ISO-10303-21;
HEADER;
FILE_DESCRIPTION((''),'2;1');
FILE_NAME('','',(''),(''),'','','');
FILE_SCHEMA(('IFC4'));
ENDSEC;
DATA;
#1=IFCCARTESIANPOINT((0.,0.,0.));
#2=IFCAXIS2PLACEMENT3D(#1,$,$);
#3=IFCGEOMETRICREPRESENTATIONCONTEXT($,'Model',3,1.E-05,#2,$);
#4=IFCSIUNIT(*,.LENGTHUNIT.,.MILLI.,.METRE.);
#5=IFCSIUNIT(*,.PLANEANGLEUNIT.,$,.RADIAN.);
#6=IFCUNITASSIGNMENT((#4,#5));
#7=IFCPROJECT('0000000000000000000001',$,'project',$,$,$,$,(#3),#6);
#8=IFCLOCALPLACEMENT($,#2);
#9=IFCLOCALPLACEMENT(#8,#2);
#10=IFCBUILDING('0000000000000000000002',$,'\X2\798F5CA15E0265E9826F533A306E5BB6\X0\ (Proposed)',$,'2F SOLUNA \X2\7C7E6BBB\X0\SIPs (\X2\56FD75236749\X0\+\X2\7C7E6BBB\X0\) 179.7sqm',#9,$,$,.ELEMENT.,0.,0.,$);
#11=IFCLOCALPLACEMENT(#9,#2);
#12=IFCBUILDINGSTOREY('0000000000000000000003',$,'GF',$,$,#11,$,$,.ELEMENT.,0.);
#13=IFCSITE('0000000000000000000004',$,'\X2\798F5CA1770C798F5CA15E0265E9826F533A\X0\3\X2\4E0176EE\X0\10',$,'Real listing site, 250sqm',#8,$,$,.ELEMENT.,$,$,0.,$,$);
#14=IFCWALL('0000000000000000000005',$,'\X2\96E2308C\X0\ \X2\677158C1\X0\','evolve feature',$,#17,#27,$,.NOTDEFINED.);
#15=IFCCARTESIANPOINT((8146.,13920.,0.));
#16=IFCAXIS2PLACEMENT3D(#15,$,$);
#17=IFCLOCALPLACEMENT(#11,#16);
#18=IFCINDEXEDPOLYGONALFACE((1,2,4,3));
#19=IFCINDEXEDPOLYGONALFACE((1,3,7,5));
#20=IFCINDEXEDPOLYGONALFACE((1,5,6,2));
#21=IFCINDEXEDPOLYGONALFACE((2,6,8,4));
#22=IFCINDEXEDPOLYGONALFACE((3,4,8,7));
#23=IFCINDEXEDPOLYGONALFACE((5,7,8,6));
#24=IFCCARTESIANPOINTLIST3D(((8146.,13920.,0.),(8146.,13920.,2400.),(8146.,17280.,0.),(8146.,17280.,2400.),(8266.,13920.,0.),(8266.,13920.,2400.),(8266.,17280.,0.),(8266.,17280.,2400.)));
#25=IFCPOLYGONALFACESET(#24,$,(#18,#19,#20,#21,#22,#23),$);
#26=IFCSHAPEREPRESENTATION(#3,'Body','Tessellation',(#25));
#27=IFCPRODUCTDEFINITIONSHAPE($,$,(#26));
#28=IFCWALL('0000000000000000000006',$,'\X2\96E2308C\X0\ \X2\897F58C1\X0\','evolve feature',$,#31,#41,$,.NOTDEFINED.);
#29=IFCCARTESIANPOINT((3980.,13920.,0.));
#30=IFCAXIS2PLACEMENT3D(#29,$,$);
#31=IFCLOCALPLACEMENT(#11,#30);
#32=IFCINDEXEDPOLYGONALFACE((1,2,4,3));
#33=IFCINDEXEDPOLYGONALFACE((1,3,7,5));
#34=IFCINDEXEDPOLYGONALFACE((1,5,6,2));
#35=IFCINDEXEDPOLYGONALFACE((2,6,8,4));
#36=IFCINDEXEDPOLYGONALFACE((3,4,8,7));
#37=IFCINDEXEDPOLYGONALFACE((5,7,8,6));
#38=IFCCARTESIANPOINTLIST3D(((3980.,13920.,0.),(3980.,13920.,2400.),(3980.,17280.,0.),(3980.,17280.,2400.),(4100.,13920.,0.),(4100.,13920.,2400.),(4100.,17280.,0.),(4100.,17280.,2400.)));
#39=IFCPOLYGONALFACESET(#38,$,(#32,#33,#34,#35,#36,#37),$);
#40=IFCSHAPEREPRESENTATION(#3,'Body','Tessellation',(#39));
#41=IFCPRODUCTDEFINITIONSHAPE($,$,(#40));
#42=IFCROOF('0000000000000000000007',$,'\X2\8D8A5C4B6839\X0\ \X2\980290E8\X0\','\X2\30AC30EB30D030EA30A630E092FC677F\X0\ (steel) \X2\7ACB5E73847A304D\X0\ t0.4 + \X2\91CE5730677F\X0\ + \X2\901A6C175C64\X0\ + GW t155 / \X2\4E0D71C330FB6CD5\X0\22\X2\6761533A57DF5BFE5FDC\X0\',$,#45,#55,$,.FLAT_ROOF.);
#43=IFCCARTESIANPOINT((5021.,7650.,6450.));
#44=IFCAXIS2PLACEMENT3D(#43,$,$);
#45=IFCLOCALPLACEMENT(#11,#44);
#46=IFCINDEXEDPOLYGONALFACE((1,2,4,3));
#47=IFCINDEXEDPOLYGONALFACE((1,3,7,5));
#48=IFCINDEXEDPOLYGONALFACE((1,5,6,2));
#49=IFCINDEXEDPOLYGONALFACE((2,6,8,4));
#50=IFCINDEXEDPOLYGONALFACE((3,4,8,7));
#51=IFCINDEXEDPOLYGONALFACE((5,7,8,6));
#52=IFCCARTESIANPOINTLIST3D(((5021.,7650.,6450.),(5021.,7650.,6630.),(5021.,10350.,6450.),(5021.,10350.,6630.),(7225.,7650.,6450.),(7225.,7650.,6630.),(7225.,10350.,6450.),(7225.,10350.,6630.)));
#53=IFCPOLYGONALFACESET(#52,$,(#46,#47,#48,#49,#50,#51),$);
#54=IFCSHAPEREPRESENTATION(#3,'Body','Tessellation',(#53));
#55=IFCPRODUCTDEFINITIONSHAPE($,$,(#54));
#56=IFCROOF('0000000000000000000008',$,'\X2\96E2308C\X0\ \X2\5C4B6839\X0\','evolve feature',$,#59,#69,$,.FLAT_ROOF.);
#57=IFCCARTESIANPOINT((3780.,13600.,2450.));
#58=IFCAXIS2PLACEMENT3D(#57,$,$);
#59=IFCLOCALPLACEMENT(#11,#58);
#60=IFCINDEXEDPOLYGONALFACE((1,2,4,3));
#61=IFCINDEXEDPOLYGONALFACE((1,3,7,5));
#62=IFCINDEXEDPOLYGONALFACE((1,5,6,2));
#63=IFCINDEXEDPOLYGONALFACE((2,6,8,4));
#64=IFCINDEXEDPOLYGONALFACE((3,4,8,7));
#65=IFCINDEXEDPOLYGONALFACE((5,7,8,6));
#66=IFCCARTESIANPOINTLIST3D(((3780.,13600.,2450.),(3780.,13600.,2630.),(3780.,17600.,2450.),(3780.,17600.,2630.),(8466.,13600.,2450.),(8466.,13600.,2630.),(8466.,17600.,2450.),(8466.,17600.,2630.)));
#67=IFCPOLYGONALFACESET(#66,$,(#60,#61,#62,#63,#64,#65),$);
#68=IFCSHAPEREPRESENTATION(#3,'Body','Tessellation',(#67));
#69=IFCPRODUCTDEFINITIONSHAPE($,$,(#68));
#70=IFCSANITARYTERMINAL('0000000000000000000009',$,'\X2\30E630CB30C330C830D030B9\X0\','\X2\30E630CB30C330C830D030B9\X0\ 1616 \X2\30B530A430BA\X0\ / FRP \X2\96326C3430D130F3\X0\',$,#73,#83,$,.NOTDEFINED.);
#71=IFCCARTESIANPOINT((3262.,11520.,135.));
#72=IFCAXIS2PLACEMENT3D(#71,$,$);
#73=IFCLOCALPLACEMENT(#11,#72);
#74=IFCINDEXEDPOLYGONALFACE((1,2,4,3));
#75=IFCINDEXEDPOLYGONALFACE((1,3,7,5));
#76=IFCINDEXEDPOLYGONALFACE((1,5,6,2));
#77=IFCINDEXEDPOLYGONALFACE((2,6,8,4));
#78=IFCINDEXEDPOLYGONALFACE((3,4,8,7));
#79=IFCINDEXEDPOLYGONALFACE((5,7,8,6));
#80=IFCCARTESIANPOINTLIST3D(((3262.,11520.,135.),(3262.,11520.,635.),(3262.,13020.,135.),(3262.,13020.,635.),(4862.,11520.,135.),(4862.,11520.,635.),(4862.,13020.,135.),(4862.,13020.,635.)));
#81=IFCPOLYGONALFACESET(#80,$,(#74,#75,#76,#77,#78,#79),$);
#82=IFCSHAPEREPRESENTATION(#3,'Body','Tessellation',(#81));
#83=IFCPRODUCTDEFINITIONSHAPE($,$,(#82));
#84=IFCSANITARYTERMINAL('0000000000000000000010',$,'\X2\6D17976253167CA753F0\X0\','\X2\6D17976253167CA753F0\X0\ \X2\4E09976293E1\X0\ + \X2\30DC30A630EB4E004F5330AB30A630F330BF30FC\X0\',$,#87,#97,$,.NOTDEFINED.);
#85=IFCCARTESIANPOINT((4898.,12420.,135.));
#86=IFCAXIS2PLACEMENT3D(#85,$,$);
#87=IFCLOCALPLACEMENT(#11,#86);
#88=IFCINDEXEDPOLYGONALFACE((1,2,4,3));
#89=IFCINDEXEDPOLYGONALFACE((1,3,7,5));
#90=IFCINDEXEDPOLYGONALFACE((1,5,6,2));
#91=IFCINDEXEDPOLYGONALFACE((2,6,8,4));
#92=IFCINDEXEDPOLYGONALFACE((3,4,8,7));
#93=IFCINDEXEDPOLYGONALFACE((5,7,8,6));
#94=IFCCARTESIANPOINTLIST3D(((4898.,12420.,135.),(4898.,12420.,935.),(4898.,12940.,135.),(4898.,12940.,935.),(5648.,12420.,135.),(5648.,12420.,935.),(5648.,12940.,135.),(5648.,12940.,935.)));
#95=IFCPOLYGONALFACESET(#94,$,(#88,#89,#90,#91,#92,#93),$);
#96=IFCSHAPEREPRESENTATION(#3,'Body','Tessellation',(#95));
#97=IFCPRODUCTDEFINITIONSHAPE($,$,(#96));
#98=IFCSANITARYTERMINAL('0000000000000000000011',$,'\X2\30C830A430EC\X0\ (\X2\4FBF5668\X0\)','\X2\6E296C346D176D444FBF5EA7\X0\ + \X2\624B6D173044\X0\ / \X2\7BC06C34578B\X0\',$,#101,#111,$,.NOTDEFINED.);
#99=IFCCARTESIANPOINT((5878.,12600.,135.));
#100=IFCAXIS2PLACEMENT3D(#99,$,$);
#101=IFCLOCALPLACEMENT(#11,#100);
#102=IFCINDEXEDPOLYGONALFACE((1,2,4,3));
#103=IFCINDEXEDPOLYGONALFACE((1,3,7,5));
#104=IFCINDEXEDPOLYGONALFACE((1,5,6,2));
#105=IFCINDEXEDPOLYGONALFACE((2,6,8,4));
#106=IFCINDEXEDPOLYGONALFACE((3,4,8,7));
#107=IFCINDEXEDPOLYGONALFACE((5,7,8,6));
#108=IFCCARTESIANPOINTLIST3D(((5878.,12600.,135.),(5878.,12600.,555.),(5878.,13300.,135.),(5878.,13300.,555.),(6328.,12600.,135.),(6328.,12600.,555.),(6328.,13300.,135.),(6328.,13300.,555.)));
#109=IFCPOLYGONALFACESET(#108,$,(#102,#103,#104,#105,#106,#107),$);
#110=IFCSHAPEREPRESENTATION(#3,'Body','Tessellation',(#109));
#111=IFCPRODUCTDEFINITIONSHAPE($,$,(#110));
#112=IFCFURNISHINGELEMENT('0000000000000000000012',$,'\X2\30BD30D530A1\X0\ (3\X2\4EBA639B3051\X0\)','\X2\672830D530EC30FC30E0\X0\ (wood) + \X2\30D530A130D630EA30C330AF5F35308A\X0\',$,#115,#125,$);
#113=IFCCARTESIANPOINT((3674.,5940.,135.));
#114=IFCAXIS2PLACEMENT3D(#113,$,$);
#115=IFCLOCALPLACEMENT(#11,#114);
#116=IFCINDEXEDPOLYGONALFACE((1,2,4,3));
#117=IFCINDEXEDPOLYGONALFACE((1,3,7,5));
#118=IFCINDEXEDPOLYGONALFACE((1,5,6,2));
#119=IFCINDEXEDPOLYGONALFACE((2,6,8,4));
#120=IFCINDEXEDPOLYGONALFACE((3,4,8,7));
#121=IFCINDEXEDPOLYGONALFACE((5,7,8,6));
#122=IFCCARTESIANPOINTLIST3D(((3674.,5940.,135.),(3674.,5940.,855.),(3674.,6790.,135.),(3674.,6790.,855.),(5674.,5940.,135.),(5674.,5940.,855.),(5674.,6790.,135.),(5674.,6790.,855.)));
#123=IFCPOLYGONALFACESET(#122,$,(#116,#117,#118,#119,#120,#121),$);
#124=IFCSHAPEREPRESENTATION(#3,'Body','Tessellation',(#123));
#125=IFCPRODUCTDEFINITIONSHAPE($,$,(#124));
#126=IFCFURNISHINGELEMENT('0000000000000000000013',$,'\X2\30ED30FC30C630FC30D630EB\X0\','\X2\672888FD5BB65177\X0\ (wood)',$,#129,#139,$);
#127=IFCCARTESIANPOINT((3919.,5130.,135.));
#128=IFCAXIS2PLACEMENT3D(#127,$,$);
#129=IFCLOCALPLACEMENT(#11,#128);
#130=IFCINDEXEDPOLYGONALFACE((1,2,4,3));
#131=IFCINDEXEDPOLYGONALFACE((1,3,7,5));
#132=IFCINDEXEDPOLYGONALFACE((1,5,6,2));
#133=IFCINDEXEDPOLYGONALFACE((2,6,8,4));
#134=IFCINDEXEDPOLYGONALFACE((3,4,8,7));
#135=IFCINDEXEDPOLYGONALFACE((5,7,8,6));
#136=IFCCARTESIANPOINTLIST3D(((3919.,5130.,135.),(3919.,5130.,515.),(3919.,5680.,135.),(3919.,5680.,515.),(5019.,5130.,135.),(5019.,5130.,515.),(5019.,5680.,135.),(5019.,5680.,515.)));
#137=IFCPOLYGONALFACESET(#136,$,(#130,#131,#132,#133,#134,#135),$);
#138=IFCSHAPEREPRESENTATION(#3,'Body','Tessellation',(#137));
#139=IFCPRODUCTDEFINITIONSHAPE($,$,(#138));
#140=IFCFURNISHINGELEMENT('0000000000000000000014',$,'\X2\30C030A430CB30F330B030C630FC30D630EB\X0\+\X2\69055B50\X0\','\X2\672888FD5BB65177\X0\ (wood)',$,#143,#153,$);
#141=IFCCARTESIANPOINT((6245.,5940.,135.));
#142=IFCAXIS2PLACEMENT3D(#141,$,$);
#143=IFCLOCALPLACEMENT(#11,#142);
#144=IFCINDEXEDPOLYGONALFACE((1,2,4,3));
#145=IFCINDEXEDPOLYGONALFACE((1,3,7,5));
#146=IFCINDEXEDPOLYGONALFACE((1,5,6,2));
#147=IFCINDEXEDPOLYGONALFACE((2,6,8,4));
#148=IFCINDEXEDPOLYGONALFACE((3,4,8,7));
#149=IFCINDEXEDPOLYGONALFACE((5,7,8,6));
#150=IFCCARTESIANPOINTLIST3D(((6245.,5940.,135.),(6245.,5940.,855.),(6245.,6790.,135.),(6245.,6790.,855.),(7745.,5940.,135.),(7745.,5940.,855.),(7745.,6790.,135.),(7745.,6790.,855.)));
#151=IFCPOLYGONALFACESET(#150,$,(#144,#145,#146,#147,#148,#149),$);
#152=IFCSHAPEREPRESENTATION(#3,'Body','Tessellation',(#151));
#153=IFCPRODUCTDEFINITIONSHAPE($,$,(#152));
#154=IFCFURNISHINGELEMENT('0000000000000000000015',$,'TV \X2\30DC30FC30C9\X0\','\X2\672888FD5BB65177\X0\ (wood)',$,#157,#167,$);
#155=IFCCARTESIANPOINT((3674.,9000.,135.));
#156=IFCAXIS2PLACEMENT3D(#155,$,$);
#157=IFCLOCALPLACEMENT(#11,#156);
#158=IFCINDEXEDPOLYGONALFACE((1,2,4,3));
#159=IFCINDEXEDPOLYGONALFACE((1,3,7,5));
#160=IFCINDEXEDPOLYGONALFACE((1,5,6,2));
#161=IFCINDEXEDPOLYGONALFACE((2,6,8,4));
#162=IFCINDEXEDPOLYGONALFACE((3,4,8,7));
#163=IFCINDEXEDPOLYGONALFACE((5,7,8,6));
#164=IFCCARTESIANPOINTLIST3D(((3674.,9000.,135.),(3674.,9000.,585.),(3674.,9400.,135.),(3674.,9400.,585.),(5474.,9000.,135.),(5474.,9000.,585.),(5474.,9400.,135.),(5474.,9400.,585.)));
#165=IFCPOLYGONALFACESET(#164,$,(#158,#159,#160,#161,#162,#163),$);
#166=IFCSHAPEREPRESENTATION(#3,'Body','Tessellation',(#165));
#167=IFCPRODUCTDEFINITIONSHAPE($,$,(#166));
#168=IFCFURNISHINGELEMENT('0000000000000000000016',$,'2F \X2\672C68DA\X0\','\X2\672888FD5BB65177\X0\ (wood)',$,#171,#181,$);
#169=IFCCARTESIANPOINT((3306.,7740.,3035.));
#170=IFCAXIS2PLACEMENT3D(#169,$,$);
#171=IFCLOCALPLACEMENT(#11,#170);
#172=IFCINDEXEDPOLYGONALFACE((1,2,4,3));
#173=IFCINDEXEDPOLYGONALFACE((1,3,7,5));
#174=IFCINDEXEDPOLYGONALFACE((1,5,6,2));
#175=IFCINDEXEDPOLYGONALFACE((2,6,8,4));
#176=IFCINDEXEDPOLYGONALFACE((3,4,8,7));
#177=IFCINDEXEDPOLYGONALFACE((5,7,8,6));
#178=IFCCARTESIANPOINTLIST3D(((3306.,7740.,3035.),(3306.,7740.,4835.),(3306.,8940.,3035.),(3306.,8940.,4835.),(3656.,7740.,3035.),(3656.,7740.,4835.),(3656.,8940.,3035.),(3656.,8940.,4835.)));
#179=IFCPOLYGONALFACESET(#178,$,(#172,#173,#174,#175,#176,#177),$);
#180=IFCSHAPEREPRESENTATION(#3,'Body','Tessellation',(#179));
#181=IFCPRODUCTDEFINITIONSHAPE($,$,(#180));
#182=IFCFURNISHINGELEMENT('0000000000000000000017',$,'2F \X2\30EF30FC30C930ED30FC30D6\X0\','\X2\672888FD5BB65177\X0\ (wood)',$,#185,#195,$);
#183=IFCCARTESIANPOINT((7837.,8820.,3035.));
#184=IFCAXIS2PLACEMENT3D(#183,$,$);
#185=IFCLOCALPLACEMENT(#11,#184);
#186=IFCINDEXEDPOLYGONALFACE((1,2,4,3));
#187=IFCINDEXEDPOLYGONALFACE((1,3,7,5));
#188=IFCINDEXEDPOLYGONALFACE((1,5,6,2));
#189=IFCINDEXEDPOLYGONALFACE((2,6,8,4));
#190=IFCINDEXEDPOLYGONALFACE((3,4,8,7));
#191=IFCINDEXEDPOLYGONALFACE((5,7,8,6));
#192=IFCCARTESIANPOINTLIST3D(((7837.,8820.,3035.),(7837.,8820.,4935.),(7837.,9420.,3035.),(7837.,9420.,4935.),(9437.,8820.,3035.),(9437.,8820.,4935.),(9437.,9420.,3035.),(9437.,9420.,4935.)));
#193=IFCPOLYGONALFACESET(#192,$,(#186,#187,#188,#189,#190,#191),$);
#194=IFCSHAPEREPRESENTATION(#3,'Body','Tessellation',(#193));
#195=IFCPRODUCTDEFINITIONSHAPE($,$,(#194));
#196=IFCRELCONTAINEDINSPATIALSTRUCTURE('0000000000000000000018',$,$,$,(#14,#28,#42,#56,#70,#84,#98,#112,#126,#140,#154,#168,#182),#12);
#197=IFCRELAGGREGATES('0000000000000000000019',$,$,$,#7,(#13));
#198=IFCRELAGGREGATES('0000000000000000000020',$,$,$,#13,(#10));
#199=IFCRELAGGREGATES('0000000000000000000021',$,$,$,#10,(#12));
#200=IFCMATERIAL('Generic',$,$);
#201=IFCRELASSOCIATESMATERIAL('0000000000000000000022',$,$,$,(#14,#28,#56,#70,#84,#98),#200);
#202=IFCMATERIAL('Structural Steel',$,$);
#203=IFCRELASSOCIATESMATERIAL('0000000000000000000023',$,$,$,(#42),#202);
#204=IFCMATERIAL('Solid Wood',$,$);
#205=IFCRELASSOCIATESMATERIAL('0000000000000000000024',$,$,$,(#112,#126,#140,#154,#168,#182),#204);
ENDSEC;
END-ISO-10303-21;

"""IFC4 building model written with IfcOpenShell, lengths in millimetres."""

from ifc_helpers import new_model, si_unit, frame, frame_2d, origin, place, context, project, spatial, rectangle, extrude, material, element, save


model = new_model("IFC4")

# Units and contexts
model_context = context("Model", 3, precision=1e-05, world=origin())
ifc_project = project(units=[si_unit("LENGTHUNIT", "METRE", prefix="MILLI"), si_unit("PLANEANGLEUNIT", "RADIAN")], contexts=[model_context])

# Site, building, storey
site_placement = place(None, origin())
site = spatial("IfcSite", under=ifc_project, at=site_placement, Name="福岡県福岡市早良区3丁目10", ObjectType="Real listing site, 250sqm", CompositionType="ELEMENT", RefElevation=0.0)
building_placement = place(site_placement, origin())
building = spatial("IfcBuilding", under=site, at=building_placement, Name="福岡市早良区の家 (Proposed)", ObjectType="2F SOLUNA 籾殻SIPs (国産杉+籾殻) 179.7sqm", CompositionType="ELEMENT", ElevationOfRefHeight=0.0, ElevationOfTerrain=0.0)
storey_placement = place(building_placement, origin())
storey = spatial("IfcBuildingStorey", under=building, at=storey_placement, Name="GF", CompositionType="ELEMENT", Elevation=0.0)

# Shared definitions
ifc_material_1 = material(Name="Generic")

# Shared definitions
ifc_material_2 = material(Name="Solid Wood")

# Walls
wall_1_placement = place(storey_placement, frame((8146.0, 13920.0, 0.0)))
element("IfcWall", 1, at=wall_1_placement, inside=storey, material=ifc_material_1, Name="離れ 東壁", Description="evolve feature", PredefinedType="NOTDEFINED", context=model_context, shape_type="SweptSolid", body=[
    extrude(rectangle(XDim=120.0, YDim=3360.0, at=frame_2d((60.0, 1680.0))), frame((8146.0, 13920.0, 0.0)), (0.0, 0.0, 1.0), 2400.0),
])
wall_2_placement = place(storey_placement, frame((3980.0, 13920.0, 0.0)))
element("IfcWall", 2, at=wall_2_placement, inside=storey, material=ifc_material_1, Name="離れ 西壁", Description="evolve feature", PredefinedType="NOTDEFINED", context=model_context, shape_type="SweptSolid", body=[
    extrude(rectangle(XDim=120.0, YDim=3360.0, at=frame_2d((60.0, 1680.0))), frame((3980.0, 13920.0, 0.0)), (0.0, 0.0, 1.0), 2400.0),
])

# Roofs
ifc_material_3 = material(Name="Structural Steel")
roof_1_placement = place(storey_placement, frame((5021.0, 7650.0, 6450.0)))
element("IfcRoof", 3, at=roof_1_placement, inside=storey, material=ifc_material_3, Name="越屋根 頂部", Description="ガルバリウム鋼板 (steel) 立平葺き t0.4 + 野地板 + 通気層 + GW t155 / 不燃・法22条区域対応", PredefinedType="FLAT_ROOF", context=model_context, shape_type="SweptSolid", body=[
    extrude(rectangle(XDim=2204.0, YDim=2700.0, at=frame_2d((1102.0, 1350.0))), frame((5021.0, 7650.0, 6450.0)), (0.0, 0.0, 1.0), 180.0),
])
roof_2_placement = place(storey_placement, frame((3780.0, 13600.0, 2450.0)))
element("IfcRoof", 4, at=roof_2_placement, inside=storey, material=ifc_material_1, Name="離れ 屋根", Description="evolve feature", PredefinedType="FLAT_ROOF", context=model_context, shape_type="SweptSolid", body=[
    extrude(rectangle(XDim=4686.0, YDim=4000.0, at=frame_2d((2343.0, 2000.0))), frame((3780.0, 13600.0, 2450.0)), (0.0, 0.0, 1.0), 180.0),
])

# Sanitary terminals
sanitary_terminal_1_placement = place(storey_placement, frame((3262.0, 11520.0, 135.0)))
element("IfcSanitaryTerminal", 5, at=sanitary_terminal_1_placement, inside=storey, material=ifc_material_1, Name="ユニットバス", Description="ユニットバス 1616 サイズ / FRP 防水パン", PredefinedType="NOTDEFINED", context=model_context, shape_type="SweptSolid", body=[
    extrude(rectangle(XDim=1600.0, YDim=1500.0, at=frame_2d((800.0, 750.0))), frame((3262.0, 11520.0, 135.0)), (0.0, 0.0, 1.0), 500.0),
])
sanitary_terminal_2_placement = place(storey_placement, frame((4898.0, 12420.0, 135.0)))
element("IfcSanitaryTerminal", 6, at=sanitary_terminal_2_placement, inside=storey, material=ifc_material_1, Name="洗面化粧台", Description="洗面化粧台 三面鏡 + ボウル一体カウンター", PredefinedType="NOTDEFINED", context=model_context, shape_type="SweptSolid", body=[
    extrude(rectangle(XDim=750.0, YDim=520.0, at=frame_2d((375.0, 260.0))), frame((4898.0, 12420.0, 135.0)), (0.0, 0.0, 1.0), 800.0),
])
sanitary_terminal_3_placement = place(storey_placement, frame((5878.0, 12600.0, 135.0)))
element("IfcSanitaryTerminal", 7, at=sanitary_terminal_3_placement, inside=storey, material=ifc_material_1, Name="トイレ (便器)", Description="温水洗浄便座 + 手洗い / 節水型", PredefinedType="NOTDEFINED", context=model_context, shape_type="SweptSolid", body=[
    extrude(rectangle(XDim=450.0, YDim=700.0, at=frame_2d((225.0, 350.0))), frame((5878.0, 12600.0, 135.0)), (0.0, 0.0, 1.0), 420.0),
])

# Furnishing elements
furnishing_1_placement = place(storey_placement, frame((3674.0, 5940.0, 135.0)))
element("IfcFurnishingElement", 8, at=furnishing_1_placement, inside=storey, material=ifc_material_2, Name="ソファ (3人掛け)", Description="木フレーム (wood) + ファブリック張り", context=model_context, shape_type="SweptSolid", body=[
    extrude(rectangle(XDim=2000.0, YDim=850.0, at=frame_2d((1000.0, 425.0))), frame((3674.0, 5940.0, 135.0)), (0.0, 0.0, 1.0), 720.0),
])
furnishing_2_placement = place(storey_placement, frame((3919.0, 5130.0, 135.0)))
element("IfcFurnishingElement", 9, at=furnishing_2_placement, inside=storey, material=ifc_material_2, Name="ローテーブル", Description="木製家具 (wood)", context=model_context, shape_type="SweptSolid", body=[
    extrude(rectangle(XDim=1100.0, YDim=550.0, at=frame_2d((550.0, 275.0))), frame((3919.0, 5130.0, 135.0)), (0.0, 0.0, 1.0), 380.0),
])
furnishing_3_placement = place(storey_placement, frame((6245.0, 5940.0, 135.0)))
element("IfcFurnishingElement", 10, at=furnishing_3_placement, inside=storey, material=ifc_material_2, Name="ダイニングテーブル+椅子", Description="木製家具 (wood)", context=model_context, shape_type="SweptSolid", body=[
    extrude(rectangle(XDim=1500.0, YDim=850.0, at=frame_2d((750.0, 425.0))), frame((6245.0, 5940.0, 135.0)), (0.0, 0.0, 1.0), 720.0),
])
furnishing_4_placement = place(storey_placement, frame((3674.0, 9000.0, 135.0)))
element("IfcFurnishingElement", 11, at=furnishing_4_placement, inside=storey, material=ifc_material_2, Name="TV ボード", Description="木製家具 (wood)", context=model_context, shape_type="SweptSolid", body=[
    extrude(rectangle(XDim=1800.0, YDim=400.0, at=frame_2d((900.0, 200.0))), frame((3674.0, 9000.0, 135.0)), (0.0, 0.0, 1.0), 450.0),
])
furnishing_5_placement = place(storey_placement, frame((3306.0, 7740.0, 3035.0)))
element("IfcFurnishingElement", 12, at=furnishing_5_placement, inside=storey, material=ifc_material_2, Name="2F 本棚", Description="木製家具 (wood)", context=model_context, shape_type="SweptSolid", body=[
    extrude(rectangle(XDim=350.0, YDim=1200.0, at=frame_2d((175.0, 600.0))), frame((3306.0, 7740.0, 3035.0)), (0.0, 0.0, 1.0), 1800.0),
])
furnishing_6_placement = place(storey_placement, frame((7837.0, 8820.0, 3035.0)))
element("IfcFurnishingElement", 13, at=furnishing_6_placement, inside=storey, material=ifc_material_2, Name="2F ワードローブ", Description="木製家具 (wood)", context=model_context, shape_type="SweptSolid", body=[
    extrude(rectangle(XDim=1600.0, YDim=600.0, at=frame_2d((800.0, 300.0))), frame((7837.0, 8820.0, 3035.0)), (0.0, 0.0, 1.0), 1900.0),
])

save(model, "model.ifc")
